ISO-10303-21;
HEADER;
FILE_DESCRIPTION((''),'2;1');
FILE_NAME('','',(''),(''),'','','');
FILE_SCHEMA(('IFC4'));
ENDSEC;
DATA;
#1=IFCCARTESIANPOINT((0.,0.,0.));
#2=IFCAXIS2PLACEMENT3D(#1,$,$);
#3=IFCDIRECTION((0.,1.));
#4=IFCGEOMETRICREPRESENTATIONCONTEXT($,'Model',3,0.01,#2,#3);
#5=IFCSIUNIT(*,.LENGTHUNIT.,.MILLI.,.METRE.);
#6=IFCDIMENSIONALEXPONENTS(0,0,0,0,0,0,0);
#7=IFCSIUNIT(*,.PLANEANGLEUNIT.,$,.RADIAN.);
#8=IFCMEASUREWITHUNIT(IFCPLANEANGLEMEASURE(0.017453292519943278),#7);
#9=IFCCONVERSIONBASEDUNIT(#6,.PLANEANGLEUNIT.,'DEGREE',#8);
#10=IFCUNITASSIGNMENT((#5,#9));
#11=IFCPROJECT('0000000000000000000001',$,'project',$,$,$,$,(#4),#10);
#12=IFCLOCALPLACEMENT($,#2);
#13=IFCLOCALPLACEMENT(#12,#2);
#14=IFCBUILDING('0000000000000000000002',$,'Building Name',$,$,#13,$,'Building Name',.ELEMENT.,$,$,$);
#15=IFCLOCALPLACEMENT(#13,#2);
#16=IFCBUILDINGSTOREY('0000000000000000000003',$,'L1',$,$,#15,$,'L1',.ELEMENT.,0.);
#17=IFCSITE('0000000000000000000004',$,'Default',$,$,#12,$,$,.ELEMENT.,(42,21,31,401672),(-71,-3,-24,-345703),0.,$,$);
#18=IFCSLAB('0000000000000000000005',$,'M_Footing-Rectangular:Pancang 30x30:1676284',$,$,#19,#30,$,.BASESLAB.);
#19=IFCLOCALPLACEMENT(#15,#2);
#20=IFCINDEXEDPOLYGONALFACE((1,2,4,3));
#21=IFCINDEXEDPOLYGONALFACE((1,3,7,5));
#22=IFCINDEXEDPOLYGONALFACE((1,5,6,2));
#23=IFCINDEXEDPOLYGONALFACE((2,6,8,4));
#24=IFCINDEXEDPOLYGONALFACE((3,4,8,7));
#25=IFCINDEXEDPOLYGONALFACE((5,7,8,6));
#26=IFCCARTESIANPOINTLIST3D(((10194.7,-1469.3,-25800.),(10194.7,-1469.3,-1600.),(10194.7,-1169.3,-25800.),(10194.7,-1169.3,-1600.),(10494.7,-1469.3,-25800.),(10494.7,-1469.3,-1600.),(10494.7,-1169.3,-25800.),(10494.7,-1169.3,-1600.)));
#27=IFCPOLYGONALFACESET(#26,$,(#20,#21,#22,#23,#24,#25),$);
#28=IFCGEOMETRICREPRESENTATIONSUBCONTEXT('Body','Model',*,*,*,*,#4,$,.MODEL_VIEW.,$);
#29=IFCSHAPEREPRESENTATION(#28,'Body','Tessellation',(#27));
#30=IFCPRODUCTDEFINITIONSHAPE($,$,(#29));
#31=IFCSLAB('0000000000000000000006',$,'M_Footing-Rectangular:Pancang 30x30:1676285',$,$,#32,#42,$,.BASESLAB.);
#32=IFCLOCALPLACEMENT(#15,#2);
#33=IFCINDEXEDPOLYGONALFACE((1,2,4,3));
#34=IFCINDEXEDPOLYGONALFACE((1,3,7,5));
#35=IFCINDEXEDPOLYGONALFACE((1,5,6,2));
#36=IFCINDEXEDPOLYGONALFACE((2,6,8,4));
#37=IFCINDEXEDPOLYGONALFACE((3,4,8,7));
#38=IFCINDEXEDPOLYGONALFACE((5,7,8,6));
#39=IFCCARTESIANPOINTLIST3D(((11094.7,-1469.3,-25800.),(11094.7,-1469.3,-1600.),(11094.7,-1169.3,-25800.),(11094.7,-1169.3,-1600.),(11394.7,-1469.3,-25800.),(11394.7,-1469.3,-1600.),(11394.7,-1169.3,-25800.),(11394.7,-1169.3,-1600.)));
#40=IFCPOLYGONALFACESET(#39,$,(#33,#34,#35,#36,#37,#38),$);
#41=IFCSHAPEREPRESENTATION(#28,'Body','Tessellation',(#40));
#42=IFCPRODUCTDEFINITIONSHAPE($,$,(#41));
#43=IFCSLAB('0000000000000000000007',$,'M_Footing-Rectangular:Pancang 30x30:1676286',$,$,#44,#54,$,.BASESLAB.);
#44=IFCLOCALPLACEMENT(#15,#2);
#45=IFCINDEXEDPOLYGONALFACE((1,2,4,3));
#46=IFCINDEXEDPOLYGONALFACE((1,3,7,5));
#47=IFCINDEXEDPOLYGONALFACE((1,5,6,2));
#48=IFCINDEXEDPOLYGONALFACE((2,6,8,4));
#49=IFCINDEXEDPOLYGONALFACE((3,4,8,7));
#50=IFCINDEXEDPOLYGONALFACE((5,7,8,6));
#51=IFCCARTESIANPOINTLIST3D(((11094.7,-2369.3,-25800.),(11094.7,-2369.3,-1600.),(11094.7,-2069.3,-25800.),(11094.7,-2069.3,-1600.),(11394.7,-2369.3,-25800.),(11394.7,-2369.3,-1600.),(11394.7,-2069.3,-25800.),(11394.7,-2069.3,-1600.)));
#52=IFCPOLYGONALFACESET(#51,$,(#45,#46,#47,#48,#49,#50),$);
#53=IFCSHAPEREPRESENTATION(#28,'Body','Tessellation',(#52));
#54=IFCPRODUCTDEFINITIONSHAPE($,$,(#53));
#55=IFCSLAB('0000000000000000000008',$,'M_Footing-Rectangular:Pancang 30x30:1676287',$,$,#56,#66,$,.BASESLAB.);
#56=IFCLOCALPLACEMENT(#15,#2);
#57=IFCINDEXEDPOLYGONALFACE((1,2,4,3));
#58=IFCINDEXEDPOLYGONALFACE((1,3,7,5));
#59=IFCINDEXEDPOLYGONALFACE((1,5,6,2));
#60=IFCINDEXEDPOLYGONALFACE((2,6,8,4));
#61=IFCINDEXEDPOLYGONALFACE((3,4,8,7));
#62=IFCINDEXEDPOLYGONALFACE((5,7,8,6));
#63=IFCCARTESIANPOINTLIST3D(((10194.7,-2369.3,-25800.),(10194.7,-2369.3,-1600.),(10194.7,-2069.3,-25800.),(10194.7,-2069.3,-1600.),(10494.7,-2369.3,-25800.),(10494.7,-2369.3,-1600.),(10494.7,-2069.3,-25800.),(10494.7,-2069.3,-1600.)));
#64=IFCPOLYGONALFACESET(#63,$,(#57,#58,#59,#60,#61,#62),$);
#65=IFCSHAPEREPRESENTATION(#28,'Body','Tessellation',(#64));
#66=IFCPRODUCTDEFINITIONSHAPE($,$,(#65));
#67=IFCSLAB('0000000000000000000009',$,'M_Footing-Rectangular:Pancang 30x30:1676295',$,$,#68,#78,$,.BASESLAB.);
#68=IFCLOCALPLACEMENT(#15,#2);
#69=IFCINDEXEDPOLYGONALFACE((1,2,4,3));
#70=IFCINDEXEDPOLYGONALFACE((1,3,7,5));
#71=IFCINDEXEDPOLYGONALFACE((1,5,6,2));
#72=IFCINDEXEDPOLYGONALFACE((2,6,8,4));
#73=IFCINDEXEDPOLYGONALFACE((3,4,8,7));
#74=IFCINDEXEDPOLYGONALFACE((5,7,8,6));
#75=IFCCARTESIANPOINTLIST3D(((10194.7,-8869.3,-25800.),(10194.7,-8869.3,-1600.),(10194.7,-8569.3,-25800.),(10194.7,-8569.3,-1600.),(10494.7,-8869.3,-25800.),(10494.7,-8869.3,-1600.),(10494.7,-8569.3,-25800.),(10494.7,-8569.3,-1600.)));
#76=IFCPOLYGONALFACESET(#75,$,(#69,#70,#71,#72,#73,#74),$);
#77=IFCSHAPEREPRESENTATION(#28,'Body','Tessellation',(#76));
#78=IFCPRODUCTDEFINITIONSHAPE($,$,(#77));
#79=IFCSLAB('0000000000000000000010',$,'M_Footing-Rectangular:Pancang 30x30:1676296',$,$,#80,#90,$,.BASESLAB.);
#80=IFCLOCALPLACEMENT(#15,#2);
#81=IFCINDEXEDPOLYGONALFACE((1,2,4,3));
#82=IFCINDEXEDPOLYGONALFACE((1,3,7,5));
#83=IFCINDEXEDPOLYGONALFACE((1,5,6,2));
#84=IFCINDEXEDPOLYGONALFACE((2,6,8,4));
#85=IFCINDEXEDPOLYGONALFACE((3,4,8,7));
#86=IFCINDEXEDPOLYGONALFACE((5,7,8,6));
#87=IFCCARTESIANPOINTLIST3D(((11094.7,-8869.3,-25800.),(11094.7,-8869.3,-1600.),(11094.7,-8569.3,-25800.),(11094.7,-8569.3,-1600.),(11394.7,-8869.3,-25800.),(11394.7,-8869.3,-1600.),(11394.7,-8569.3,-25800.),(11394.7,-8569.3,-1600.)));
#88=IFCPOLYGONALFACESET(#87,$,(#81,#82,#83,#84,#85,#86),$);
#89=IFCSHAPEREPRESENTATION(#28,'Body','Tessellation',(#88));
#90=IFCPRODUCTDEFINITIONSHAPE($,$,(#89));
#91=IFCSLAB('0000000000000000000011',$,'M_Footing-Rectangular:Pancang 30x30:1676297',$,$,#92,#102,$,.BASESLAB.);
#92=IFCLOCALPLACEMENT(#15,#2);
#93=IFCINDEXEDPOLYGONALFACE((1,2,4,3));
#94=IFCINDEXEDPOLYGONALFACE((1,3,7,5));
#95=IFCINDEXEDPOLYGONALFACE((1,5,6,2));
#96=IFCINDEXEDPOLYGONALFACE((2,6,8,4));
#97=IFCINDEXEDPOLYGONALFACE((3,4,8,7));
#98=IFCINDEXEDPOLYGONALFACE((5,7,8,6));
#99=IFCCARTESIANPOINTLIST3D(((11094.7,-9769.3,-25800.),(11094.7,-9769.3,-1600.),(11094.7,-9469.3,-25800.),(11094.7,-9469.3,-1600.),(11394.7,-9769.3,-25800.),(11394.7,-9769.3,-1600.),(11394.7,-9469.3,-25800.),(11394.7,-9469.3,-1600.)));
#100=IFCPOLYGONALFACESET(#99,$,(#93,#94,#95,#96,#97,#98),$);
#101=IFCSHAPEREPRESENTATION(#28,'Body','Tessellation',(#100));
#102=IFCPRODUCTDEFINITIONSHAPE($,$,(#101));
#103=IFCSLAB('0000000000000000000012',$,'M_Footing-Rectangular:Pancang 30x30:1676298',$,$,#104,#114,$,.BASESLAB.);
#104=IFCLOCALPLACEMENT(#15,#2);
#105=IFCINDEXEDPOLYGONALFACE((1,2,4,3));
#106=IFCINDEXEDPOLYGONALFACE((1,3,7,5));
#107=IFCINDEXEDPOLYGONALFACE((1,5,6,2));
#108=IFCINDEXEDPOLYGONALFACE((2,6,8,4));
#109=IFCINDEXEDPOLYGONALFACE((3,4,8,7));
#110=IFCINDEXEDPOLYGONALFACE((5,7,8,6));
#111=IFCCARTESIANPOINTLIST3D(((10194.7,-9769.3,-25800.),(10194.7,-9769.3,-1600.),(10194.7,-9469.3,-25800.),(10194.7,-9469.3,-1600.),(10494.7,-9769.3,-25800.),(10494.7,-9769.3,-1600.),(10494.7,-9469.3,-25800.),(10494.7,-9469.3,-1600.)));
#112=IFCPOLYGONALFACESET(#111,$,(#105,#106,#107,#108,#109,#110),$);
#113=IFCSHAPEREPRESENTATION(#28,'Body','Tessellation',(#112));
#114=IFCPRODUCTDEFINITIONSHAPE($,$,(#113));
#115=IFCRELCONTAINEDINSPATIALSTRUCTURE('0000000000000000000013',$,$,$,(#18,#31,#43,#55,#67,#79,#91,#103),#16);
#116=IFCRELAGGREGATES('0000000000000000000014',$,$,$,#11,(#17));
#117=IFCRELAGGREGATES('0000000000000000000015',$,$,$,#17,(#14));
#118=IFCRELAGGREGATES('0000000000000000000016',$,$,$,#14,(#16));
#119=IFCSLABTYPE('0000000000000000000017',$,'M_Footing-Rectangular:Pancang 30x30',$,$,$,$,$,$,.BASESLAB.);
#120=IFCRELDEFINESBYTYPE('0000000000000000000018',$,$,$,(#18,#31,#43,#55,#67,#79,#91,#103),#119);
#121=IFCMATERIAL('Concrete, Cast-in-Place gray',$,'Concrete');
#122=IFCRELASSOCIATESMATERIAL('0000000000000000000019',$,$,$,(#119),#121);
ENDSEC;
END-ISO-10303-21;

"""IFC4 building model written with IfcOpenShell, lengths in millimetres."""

from ifc_helpers import new_model, entity, si_unit, converted_unit, direction, frame, origin, place, context, subcontext, project, spatial, indexed_curve, outline, extrude, material, type_object, element, save


model = new_model("IFC4")

# Units and contexts
model_context = context("Model", 3, precision=0.01, world=origin(), true_north=direction((0.0, 1.0)))
body_context = subcontext(model_context, "Body", "Model", "MODEL_VIEW")
ifc_project = project(units=[si_unit("LENGTHUNIT", "METRE", prefix="MILLI"), converted_unit("PLANEANGLEUNIT", "DEGREE", entity("IfcPlaneAngleMeasure", 0.017453292519943278), si_unit("PLANEANGLEUNIT", "RADIAN"), dimensions=[0, 0, 0, 0, 0, 0, 0])], contexts=[model_context])

# Site, building, storey
site_placement = place(None, origin())
site = spatial("IfcSite", under=ifc_project, at=site_placement, Name="Default", CompositionType="ELEMENT", RefLatitude=(42, 21, 31, 401672), RefLongitude=(-71, -3, -24, -345703), RefElevation=0.0)
building_placement = place(site_placement, origin())
building = spatial("IfcBuilding", under=site, at=building_placement, Name="Building Name", LongName="Building Name", CompositionType="ELEMENT")
storey_placement = place(building_placement, origin())
storey = spatial("IfcBuildingStorey", under=building, at=storey_placement, Name="L1", LongName="L1", CompositionType="ELEMENT", Elevation=0.0)

# Slabs
ifc_material = material(Name="Concrete, Cast-in-Place gray", Category="Concrete")
slab_type = type_object("IfcSlabType", Name="M_Footing-Rectangular:Pancang 30x30", PredefinedType="BASESLAB", material=ifc_material)
slab_1_placement = place(storey_placement, origin())
element("IfcSlab", 1, at=slab_1_placement, inside=storey, type_object=slab_type, Name="M_Footing-Rectangular:Pancang 30x30:1676284", PredefinedType="BASESLAB", context=body_context, shape_type="SweptSolid", body=[
    extrude(outline(indexed_curve([(-150.0, -150.0), (150.0, -150.0), (150.0, 150.0), (-150.0, 150.0), (-150.0, -150.0)], self_intersect=False)), frame((10344.7, -1319.3, -25800.0), z_axis=(0.0, 0.0, 1.0), x_axis=(-1.0, 0.0, 0.0)), (0.0, 0.0, 1.0), 24200.0),
])
slab_2_placement = place(storey_placement, origin())
element("IfcSlab", 2, at=slab_2_placement, inside=storey, type_object=slab_type, Name="M_Footing-Rectangular:Pancang 30x30:1676285", PredefinedType="BASESLAB", context=body_context, shape_type="SweptSolid", body=[
    extrude(outline(indexed_curve([(-150.0, -150.0), (150.0, -150.0), (150.0, 150.0), (-150.0, 150.0), (-150.0, -150.0)], self_intersect=False)), frame((11244.7, -1319.3, -25800.0), z_axis=(0.0, 0.0, 1.0), x_axis=(-1.0, 0.0, 0.0)), (0.0, 0.0, 1.0), 24200.0),
])
slab_3_placement = place(storey_placement, origin())
element("IfcSlab", 3, at=slab_3_placement, inside=storey, type_object=slab_type, Name="M_Footing-Rectangular:Pancang 30x30:1676286", PredefinedType="BASESLAB", context=body_context, shape_type="SweptSolid", body=[
    extrude(outline(indexed_curve([(-150.0, -150.0), (150.0, -150.0), (150.0, 150.0), (-150.0, 150.0), (-150.0, -150.0)], self_intersect=False)), frame((11244.7, -2219.3, -25800.0), z_axis=(0.0, 0.0, 1.0), x_axis=(-1.0, 0.0, 0.0)), (0.0, 0.0, 1.0), 24200.0),
])
slab_4_placement = place(storey_placement, origin())
element("IfcSlab", 4, at=slab_4_placement, inside=storey, type_object=slab_type, Name="M_Footing-Rectangular:Pancang 30x30:1676287", PredefinedType="BASESLAB", context=body_context, shape_type="SweptSolid", body=[
    extrude(outline(indexed_curve([(-150.0, -150.0), (150.0, -150.0), (150.0, 150.0), (-150.0, 150.0), (-150.0, -150.0)], self_intersect=False)), frame((10344.7, -2219.3, -25800.0), z_axis=(0.0, 0.0, 1.0), x_axis=(-1.0, 0.0, 0.0)), (0.0, 0.0, 1.0), 24200.0),
])
slab_5_placement = place(storey_placement, origin())
element("IfcSlab", 5, at=slab_5_placement, inside=storey, type_object=slab_type, Name="M_Footing-Rectangular:Pancang 30x30:1676295", PredefinedType="BASESLAB", context=body_context, shape_type="SweptSolid", body=[
    extrude(outline(indexed_curve([(-150.0, -150.0), (150.0, -150.0), (150.0, 150.0), (-150.0, 150.0), (-150.0, -150.0)], self_intersect=False)), frame((10344.7, -8719.3, -25800.0), z_axis=(0.0, 0.0, 1.0), x_axis=(-1.0, 0.0, 0.0)), (0.0, 0.0, 1.0), 24200.0),
])
slab_6_placement = place(storey_placement, origin())
element("IfcSlab", 6, at=slab_6_placement, inside=storey, type_object=slab_type, Name="M_Footing-Rectangular:Pancang 30x30:1676296", PredefinedType="BASESLAB", context=body_context, shape_type="SweptSolid", body=[
    extrude(outline(indexed_curve([(-150.0, -150.0), (150.0, -150.0), (150.0, 150.0), (-150.0, 150.0), (-150.0, -150.0)], self_intersect=False)), frame((11244.7, -8719.3, -25800.0), z_axis=(0.0, 0.0, 1.0), x_axis=(-1.0, 0.0, 0.0)), (0.0, 0.0, 1.0), 24200.0),
])
slab_7_placement = place(storey_placement, origin())
element("IfcSlab", 7, at=slab_7_placement, inside=storey, type_object=slab_type, Name="M_Footing-Rectangular:Pancang 30x30:1676297", PredefinedType="BASESLAB", context=body_context, shape_type="SweptSolid", body=[
    extrude(outline(indexed_curve([(-150.0, -150.0), (150.0, -150.0), (150.0, 150.0), (-150.0, 150.0), (-150.0, -150.0)], self_intersect=False)), frame((11244.7, -9619.3, -25800.0), z_axis=(0.0, 0.0, 1.0), x_axis=(-1.0, 0.0, 0.0)), (0.0, 0.0, 1.0), 24200.0),
])
slab_8_placement = place(storey_placement, origin())
element("IfcSlab", 8, at=slab_8_placement, inside=storey, type_object=slab_type, Name="M_Footing-Rectangular:Pancang 30x30:1676298", PredefinedType="BASESLAB", context=body_context, shape_type="SweptSolid", body=[
    extrude(outline(indexed_curve([(-150.0, -150.0), (150.0, -150.0), (150.0, 150.0), (-150.0, 150.0), (-150.0, -150.0)], self_intersect=False)), frame((10344.7, -9619.3, -25800.0), z_axis=(0.0, 0.0, 1.0), x_axis=(-1.0, 0.0, 0.0)), (0.0, 0.0, 1.0), 24200.0),
])

save(model, "model.ifc")
